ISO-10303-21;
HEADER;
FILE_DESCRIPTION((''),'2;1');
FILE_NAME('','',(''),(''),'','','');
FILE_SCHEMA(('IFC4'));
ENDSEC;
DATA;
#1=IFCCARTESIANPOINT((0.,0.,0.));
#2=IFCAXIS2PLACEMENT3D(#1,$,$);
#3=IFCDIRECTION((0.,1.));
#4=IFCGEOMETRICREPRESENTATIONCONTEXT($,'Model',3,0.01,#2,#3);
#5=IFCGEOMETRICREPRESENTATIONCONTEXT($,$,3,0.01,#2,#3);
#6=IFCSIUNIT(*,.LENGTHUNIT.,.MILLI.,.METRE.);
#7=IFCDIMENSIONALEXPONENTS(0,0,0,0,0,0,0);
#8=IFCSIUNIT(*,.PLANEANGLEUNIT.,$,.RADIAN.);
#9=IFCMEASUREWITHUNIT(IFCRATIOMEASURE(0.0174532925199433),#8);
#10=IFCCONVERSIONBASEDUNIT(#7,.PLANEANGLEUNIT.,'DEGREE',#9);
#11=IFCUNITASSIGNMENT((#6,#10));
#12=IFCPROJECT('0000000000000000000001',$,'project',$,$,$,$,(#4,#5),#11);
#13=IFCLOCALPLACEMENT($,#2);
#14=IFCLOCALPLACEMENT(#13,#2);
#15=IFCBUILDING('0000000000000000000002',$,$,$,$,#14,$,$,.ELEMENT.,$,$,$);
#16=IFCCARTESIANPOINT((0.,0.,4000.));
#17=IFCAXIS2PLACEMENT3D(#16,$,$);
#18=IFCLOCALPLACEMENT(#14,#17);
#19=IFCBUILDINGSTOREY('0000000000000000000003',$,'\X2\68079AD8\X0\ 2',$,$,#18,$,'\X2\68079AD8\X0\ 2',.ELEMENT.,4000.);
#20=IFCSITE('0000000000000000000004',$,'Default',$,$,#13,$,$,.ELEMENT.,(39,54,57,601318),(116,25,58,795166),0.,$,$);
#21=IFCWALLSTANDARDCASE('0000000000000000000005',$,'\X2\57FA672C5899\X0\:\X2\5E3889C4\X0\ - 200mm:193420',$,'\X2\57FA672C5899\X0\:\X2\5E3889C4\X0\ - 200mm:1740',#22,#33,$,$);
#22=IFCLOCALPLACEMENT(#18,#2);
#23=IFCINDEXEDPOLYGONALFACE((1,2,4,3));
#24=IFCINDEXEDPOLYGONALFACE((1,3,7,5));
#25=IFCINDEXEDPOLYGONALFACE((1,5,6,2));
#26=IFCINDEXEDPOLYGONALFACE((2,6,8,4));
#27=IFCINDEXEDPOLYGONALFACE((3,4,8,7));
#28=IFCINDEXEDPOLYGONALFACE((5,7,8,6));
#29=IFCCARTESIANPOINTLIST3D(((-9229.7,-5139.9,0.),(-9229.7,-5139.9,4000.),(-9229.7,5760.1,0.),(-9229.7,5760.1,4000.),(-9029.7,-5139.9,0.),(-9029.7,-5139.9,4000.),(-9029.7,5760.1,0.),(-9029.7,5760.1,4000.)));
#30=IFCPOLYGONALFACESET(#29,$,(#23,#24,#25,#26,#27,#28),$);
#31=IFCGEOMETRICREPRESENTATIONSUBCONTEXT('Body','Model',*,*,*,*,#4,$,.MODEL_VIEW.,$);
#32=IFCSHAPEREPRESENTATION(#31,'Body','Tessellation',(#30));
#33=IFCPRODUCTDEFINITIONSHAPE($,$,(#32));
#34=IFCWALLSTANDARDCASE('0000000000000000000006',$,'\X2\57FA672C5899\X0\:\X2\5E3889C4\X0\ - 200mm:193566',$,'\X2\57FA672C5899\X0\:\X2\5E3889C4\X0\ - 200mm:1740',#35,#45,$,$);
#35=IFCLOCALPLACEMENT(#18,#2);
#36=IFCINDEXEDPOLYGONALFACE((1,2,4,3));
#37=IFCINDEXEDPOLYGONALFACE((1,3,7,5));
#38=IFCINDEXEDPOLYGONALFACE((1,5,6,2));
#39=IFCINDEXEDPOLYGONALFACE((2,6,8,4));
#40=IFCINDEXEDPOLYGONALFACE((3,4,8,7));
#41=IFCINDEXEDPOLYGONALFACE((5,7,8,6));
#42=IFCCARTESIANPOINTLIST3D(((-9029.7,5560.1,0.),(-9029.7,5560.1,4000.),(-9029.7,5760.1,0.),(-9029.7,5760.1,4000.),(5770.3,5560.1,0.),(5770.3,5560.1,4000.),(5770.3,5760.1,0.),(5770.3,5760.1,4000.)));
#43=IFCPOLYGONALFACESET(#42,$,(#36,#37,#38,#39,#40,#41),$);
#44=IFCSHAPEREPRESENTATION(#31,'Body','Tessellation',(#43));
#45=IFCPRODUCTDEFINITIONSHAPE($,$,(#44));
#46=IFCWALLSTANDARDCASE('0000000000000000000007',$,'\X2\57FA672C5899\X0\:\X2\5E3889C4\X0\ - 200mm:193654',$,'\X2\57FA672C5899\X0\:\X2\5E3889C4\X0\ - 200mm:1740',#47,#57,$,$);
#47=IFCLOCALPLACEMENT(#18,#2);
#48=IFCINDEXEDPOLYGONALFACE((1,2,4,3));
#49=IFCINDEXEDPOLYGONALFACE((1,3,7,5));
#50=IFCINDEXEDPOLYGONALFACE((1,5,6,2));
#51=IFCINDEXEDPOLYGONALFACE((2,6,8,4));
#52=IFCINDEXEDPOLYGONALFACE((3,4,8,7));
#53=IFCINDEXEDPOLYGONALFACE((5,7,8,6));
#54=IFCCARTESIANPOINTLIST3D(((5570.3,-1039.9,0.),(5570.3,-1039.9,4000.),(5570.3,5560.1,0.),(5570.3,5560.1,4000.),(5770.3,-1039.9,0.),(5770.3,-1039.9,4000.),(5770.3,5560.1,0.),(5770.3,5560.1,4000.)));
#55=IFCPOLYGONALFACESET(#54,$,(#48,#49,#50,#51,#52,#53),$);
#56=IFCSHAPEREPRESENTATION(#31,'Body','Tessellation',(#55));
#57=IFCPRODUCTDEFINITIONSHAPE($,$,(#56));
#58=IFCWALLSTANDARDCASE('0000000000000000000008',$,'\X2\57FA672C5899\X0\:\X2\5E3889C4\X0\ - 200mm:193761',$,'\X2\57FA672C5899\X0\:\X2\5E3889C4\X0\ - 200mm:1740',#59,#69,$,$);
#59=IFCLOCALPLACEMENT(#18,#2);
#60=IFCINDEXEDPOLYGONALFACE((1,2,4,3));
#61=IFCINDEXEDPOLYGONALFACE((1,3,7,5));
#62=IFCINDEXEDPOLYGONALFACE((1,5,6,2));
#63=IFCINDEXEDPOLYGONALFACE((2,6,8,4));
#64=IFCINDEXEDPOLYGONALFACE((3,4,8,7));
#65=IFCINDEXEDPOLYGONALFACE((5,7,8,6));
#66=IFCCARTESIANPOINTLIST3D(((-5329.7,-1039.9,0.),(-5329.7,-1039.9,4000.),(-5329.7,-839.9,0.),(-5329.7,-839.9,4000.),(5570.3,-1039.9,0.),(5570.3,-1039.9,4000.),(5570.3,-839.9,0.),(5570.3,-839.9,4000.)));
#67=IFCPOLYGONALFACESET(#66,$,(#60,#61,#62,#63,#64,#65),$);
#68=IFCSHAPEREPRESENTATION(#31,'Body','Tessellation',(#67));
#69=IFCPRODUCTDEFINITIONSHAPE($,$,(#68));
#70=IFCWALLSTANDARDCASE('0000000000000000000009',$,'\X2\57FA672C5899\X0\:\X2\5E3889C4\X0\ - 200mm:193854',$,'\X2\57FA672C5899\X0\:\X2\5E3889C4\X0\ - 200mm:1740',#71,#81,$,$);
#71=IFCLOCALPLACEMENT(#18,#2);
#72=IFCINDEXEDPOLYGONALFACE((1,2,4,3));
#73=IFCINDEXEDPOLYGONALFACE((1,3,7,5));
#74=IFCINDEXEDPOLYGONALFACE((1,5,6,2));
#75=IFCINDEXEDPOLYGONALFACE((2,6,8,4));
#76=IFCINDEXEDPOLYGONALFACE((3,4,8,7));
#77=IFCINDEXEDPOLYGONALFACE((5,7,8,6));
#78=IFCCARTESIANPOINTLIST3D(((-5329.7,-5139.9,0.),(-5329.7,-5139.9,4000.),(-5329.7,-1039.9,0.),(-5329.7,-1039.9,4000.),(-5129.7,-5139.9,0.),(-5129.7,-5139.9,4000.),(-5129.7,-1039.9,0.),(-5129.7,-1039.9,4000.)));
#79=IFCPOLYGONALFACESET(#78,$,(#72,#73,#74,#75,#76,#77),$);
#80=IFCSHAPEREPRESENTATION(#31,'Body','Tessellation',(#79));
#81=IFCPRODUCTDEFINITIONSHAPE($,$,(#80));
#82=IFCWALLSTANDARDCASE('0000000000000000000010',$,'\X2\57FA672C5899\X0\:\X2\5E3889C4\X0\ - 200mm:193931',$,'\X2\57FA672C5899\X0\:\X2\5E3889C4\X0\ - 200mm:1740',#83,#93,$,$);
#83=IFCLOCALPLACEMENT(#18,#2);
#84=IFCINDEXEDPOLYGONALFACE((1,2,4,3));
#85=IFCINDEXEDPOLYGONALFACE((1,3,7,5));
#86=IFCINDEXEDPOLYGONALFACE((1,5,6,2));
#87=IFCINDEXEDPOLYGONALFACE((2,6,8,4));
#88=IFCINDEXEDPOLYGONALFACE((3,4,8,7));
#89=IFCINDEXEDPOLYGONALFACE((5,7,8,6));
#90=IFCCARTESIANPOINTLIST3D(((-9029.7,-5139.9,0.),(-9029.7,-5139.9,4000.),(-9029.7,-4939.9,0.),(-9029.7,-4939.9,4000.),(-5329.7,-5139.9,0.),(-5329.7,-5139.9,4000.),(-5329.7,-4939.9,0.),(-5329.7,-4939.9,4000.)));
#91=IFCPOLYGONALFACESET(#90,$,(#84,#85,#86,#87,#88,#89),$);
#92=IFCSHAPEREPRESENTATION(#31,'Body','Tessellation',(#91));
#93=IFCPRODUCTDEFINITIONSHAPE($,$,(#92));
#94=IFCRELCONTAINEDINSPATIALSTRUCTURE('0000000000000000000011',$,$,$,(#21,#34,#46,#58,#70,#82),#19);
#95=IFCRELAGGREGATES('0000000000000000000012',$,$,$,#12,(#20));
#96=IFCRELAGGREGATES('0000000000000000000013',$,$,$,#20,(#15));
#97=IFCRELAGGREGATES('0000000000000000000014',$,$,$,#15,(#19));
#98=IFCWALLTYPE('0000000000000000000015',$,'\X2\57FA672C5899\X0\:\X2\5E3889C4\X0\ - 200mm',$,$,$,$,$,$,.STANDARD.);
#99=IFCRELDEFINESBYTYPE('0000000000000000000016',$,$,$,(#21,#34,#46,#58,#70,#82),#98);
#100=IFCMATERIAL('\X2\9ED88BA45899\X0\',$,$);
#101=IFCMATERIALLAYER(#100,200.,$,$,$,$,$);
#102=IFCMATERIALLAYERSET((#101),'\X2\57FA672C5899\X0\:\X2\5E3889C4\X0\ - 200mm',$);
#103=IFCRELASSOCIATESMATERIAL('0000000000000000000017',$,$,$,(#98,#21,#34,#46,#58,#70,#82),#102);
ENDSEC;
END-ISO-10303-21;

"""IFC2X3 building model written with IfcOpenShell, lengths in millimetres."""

from ifc_helpers import new_model, entity, si_unit, converted_unit, direction, frame, frame_2d, origin, place, context, subcontext, project, spatial, rectangle, extrude, material, layer, layer_set, layer_usage, type_object, element, save


model = new_model("IFC2X3")

# Units and contexts
model_context = context("Model", 3, precision=0.01, world=origin(), true_north=direction((0.0, 1.0)))
context_of_model = context(None, 3, precision=0.01, world=origin(), true_north=direction((0.0, 1.0)))
body_context = subcontext(model_context, "Body", "Model", "MODEL_VIEW")
ifc_project = project(units=[si_unit("LENGTHUNIT", "METRE", prefix="MILLI"), converted_unit("PLANEANGLEUNIT", "DEGREE", entity("IfcRatioMeasure", 0.0174532925199433), si_unit("PLANEANGLEUNIT", "RADIAN"), dimensions=[0, 0, 0, 0, 0, 0, 0])], contexts=[model_context, context_of_model])

# Site, building, storey
site_placement = place(None, origin())
site = spatial("IfcSite", under=ifc_project, at=site_placement, Name="Default", CompositionType="ELEMENT", RefLatitude=(39, 54, 57, 601318), RefLongitude=(116, 25, 58, 795166), RefElevation=0.0)
building_placement = place(site_placement, origin())
building = spatial("IfcBuilding", under=site, at=building_placement, CompositionType="ELEMENT")
storey_placement = place(building_placement, frame((0.0, 0.0, 4000.0)))
storey = spatial("IfcBuildingStorey", under=building, at=storey_placement, Name="标高 2", LongName="标高 2", CompositionType="ELEMENT", Elevation=4000.0)

# Walls
ifc_material = material(Name="默认墙")
ifc_layer = layer(ifc_material, 200.0)
ifc_layer_set = layer_set([ifc_layer], Name="基本墙:常规 - 200mm")
ifc_layer_usage_1 = layer_usage(ifc_layer_set, "AXIS2", "NEGATIVE", 100.0)
wall_type = type_object("IfcWallType", Name="基本墙:常规 - 200mm", PredefinedType="STANDARD", material=ifc_layer_set)
wall_1_placement = place(storey_placement, frame((-9129.7, -5139.9, 0.0), z_axis=(0.0, 0.0, 1.0), x_axis=(0.0, 1.0, 0.0)))
element("IfcWallStandardCase", 1, at=wall_1_placement, inside=storey, type_object=wall_type, material=ifc_layer_usage_1, Name="基本墙:常规 - 200mm:193420", ObjectType="基本墙:常规 - 200mm:1740", context=body_context, shape_type="SweptSolid", body=[
    extrude(rectangle(XDim=10900.0, YDim=200.0, at=frame_2d((5450.0, 0.0), x_axis=(-1.0, 0.0))), origin(), (0.0, 0.0, 1.0), 4000.0),
])
ifc_layer_usage_2 = layer_usage(ifc_layer_set, "AXIS2", "NEGATIVE", 100.0)
wall_2_placement = place(storey_placement, frame((-9029.7, 5660.1, 0.0)))
element("IfcWallStandardCase", 2, at=wall_2_placement, inside=storey, type_object=wall_type, material=ifc_layer_usage_2, Name="基本墙:常规 - 200mm:193566", ObjectType="基本墙:常规 - 200mm:1740", context=body_context, shape_type="SweptSolid", body=[
    extrude(rectangle(XDim=14800.0, YDim=200.0, at=frame_2d((7400.0, 0.0), x_axis=(-1.0, 0.0))), origin(), (0.0, 0.0, 1.0), 4000.0),
])
ifc_layer_usage_3 = layer_usage(ifc_layer_set, "AXIS2", "NEGATIVE", 100.0)
wall_3_placement = place(storey_placement, frame((5670.3, 5560.1, 0.0), z_axis=(0.0, 0.0, 1.0), x_axis=(0.0, -1.0, 0.0)))
element("IfcWallStandardCase", 3, at=wall_3_placement, inside=storey, type_object=wall_type, material=ifc_layer_usage_3, Name="基本墙:常规 - 200mm:193654", ObjectType="基本墙:常规 - 200mm:1740", context=body_context, shape_type="SweptSolid", body=[
    extrude(rectangle(XDim=6600.0, YDim=200.0, at=frame_2d((3300.0, 0.0), x_axis=(-1.0, 0.0))), origin(), (0.0, 0.0, 1.0), 4000.0),
])
ifc_layer_usage_4 = layer_usage(ifc_layer_set, "AXIS2", "NEGATIVE", 100.0)
wall_4_placement = place(storey_placement, frame((5570.3, -939.9, 0.0), z_axis=(0.0, 0.0, 1.0), x_axis=(-1.0, 0.0, 0.0)))
element("IfcWallStandardCase", 4, at=wall_4_placement, inside=storey, type_object=wall_type, material=ifc_layer_usage_4, Name="基本墙:常规 - 200mm:193761", ObjectType="基本墙:常规 - 200mm:1740", context=body_context, shape_type="SweptSolid", body=[
    extrude(rectangle(XDim=10900.0, YDim=200.0, at=frame_2d((5450.0, 0.0), x_axis=(-1.0, 0.0))), origin(), (0.0, 0.0, 1.0), 4000.0),
])
ifc_layer_usage_5 = layer_usage(ifc_layer_set, "AXIS2", "NEGATIVE", 100.0)
wall_5_placement = place(storey_placement, frame((-5229.7, -1039.9, 0.0), z_axis=(0.0, 0.0, 1.0), x_axis=(0.0, -1.0, 0.0)))
element("IfcWallStandardCase", 5, at=wall_5_placement, inside=storey, type_object=wall_type, material=ifc_layer_usage_5, Name="基本墙:常规 - 200mm:193854", ObjectType="基本墙:常规 - 200mm:1740", context=body_context, shape_type="SweptSolid", body=[
    extrude(rectangle(XDim=4100.0, YDim=200.0, at=frame_2d((2050.0, 0.0), x_axis=(-1.0, 0.0))), origin(), (0.0, 0.0, 1.0), 4000.0),
])
ifc_layer_usage_6 = layer_usage(ifc_layer_set, "AXIS2", "NEGATIVE", 100.0)
wall_6_placement = place(storey_placement, frame((-5329.7, -5039.9, 0.0), z_axis=(0.0, 0.0, 1.0), x_axis=(-1.0, 0.0, 0.0)))
element("IfcWallStandardCase", 6, at=wall_6_placement, inside=storey, type_object=wall_type, material=ifc_layer_usage_6, Name="基本墙:常规 - 200mm:193931", ObjectType="基本墙:常规 - 200mm:1740", context=body_context, shape_type="SweptSolid", body=[
    extrude(rectangle(XDim=3700.0, YDim=200.0, at=frame_2d((1850.0, 0.0), x_axis=(-1.0, 0.0))), origin(), (0.0, 0.0, 1.0), 4000.0),
])

save(model, "model.ifc")
